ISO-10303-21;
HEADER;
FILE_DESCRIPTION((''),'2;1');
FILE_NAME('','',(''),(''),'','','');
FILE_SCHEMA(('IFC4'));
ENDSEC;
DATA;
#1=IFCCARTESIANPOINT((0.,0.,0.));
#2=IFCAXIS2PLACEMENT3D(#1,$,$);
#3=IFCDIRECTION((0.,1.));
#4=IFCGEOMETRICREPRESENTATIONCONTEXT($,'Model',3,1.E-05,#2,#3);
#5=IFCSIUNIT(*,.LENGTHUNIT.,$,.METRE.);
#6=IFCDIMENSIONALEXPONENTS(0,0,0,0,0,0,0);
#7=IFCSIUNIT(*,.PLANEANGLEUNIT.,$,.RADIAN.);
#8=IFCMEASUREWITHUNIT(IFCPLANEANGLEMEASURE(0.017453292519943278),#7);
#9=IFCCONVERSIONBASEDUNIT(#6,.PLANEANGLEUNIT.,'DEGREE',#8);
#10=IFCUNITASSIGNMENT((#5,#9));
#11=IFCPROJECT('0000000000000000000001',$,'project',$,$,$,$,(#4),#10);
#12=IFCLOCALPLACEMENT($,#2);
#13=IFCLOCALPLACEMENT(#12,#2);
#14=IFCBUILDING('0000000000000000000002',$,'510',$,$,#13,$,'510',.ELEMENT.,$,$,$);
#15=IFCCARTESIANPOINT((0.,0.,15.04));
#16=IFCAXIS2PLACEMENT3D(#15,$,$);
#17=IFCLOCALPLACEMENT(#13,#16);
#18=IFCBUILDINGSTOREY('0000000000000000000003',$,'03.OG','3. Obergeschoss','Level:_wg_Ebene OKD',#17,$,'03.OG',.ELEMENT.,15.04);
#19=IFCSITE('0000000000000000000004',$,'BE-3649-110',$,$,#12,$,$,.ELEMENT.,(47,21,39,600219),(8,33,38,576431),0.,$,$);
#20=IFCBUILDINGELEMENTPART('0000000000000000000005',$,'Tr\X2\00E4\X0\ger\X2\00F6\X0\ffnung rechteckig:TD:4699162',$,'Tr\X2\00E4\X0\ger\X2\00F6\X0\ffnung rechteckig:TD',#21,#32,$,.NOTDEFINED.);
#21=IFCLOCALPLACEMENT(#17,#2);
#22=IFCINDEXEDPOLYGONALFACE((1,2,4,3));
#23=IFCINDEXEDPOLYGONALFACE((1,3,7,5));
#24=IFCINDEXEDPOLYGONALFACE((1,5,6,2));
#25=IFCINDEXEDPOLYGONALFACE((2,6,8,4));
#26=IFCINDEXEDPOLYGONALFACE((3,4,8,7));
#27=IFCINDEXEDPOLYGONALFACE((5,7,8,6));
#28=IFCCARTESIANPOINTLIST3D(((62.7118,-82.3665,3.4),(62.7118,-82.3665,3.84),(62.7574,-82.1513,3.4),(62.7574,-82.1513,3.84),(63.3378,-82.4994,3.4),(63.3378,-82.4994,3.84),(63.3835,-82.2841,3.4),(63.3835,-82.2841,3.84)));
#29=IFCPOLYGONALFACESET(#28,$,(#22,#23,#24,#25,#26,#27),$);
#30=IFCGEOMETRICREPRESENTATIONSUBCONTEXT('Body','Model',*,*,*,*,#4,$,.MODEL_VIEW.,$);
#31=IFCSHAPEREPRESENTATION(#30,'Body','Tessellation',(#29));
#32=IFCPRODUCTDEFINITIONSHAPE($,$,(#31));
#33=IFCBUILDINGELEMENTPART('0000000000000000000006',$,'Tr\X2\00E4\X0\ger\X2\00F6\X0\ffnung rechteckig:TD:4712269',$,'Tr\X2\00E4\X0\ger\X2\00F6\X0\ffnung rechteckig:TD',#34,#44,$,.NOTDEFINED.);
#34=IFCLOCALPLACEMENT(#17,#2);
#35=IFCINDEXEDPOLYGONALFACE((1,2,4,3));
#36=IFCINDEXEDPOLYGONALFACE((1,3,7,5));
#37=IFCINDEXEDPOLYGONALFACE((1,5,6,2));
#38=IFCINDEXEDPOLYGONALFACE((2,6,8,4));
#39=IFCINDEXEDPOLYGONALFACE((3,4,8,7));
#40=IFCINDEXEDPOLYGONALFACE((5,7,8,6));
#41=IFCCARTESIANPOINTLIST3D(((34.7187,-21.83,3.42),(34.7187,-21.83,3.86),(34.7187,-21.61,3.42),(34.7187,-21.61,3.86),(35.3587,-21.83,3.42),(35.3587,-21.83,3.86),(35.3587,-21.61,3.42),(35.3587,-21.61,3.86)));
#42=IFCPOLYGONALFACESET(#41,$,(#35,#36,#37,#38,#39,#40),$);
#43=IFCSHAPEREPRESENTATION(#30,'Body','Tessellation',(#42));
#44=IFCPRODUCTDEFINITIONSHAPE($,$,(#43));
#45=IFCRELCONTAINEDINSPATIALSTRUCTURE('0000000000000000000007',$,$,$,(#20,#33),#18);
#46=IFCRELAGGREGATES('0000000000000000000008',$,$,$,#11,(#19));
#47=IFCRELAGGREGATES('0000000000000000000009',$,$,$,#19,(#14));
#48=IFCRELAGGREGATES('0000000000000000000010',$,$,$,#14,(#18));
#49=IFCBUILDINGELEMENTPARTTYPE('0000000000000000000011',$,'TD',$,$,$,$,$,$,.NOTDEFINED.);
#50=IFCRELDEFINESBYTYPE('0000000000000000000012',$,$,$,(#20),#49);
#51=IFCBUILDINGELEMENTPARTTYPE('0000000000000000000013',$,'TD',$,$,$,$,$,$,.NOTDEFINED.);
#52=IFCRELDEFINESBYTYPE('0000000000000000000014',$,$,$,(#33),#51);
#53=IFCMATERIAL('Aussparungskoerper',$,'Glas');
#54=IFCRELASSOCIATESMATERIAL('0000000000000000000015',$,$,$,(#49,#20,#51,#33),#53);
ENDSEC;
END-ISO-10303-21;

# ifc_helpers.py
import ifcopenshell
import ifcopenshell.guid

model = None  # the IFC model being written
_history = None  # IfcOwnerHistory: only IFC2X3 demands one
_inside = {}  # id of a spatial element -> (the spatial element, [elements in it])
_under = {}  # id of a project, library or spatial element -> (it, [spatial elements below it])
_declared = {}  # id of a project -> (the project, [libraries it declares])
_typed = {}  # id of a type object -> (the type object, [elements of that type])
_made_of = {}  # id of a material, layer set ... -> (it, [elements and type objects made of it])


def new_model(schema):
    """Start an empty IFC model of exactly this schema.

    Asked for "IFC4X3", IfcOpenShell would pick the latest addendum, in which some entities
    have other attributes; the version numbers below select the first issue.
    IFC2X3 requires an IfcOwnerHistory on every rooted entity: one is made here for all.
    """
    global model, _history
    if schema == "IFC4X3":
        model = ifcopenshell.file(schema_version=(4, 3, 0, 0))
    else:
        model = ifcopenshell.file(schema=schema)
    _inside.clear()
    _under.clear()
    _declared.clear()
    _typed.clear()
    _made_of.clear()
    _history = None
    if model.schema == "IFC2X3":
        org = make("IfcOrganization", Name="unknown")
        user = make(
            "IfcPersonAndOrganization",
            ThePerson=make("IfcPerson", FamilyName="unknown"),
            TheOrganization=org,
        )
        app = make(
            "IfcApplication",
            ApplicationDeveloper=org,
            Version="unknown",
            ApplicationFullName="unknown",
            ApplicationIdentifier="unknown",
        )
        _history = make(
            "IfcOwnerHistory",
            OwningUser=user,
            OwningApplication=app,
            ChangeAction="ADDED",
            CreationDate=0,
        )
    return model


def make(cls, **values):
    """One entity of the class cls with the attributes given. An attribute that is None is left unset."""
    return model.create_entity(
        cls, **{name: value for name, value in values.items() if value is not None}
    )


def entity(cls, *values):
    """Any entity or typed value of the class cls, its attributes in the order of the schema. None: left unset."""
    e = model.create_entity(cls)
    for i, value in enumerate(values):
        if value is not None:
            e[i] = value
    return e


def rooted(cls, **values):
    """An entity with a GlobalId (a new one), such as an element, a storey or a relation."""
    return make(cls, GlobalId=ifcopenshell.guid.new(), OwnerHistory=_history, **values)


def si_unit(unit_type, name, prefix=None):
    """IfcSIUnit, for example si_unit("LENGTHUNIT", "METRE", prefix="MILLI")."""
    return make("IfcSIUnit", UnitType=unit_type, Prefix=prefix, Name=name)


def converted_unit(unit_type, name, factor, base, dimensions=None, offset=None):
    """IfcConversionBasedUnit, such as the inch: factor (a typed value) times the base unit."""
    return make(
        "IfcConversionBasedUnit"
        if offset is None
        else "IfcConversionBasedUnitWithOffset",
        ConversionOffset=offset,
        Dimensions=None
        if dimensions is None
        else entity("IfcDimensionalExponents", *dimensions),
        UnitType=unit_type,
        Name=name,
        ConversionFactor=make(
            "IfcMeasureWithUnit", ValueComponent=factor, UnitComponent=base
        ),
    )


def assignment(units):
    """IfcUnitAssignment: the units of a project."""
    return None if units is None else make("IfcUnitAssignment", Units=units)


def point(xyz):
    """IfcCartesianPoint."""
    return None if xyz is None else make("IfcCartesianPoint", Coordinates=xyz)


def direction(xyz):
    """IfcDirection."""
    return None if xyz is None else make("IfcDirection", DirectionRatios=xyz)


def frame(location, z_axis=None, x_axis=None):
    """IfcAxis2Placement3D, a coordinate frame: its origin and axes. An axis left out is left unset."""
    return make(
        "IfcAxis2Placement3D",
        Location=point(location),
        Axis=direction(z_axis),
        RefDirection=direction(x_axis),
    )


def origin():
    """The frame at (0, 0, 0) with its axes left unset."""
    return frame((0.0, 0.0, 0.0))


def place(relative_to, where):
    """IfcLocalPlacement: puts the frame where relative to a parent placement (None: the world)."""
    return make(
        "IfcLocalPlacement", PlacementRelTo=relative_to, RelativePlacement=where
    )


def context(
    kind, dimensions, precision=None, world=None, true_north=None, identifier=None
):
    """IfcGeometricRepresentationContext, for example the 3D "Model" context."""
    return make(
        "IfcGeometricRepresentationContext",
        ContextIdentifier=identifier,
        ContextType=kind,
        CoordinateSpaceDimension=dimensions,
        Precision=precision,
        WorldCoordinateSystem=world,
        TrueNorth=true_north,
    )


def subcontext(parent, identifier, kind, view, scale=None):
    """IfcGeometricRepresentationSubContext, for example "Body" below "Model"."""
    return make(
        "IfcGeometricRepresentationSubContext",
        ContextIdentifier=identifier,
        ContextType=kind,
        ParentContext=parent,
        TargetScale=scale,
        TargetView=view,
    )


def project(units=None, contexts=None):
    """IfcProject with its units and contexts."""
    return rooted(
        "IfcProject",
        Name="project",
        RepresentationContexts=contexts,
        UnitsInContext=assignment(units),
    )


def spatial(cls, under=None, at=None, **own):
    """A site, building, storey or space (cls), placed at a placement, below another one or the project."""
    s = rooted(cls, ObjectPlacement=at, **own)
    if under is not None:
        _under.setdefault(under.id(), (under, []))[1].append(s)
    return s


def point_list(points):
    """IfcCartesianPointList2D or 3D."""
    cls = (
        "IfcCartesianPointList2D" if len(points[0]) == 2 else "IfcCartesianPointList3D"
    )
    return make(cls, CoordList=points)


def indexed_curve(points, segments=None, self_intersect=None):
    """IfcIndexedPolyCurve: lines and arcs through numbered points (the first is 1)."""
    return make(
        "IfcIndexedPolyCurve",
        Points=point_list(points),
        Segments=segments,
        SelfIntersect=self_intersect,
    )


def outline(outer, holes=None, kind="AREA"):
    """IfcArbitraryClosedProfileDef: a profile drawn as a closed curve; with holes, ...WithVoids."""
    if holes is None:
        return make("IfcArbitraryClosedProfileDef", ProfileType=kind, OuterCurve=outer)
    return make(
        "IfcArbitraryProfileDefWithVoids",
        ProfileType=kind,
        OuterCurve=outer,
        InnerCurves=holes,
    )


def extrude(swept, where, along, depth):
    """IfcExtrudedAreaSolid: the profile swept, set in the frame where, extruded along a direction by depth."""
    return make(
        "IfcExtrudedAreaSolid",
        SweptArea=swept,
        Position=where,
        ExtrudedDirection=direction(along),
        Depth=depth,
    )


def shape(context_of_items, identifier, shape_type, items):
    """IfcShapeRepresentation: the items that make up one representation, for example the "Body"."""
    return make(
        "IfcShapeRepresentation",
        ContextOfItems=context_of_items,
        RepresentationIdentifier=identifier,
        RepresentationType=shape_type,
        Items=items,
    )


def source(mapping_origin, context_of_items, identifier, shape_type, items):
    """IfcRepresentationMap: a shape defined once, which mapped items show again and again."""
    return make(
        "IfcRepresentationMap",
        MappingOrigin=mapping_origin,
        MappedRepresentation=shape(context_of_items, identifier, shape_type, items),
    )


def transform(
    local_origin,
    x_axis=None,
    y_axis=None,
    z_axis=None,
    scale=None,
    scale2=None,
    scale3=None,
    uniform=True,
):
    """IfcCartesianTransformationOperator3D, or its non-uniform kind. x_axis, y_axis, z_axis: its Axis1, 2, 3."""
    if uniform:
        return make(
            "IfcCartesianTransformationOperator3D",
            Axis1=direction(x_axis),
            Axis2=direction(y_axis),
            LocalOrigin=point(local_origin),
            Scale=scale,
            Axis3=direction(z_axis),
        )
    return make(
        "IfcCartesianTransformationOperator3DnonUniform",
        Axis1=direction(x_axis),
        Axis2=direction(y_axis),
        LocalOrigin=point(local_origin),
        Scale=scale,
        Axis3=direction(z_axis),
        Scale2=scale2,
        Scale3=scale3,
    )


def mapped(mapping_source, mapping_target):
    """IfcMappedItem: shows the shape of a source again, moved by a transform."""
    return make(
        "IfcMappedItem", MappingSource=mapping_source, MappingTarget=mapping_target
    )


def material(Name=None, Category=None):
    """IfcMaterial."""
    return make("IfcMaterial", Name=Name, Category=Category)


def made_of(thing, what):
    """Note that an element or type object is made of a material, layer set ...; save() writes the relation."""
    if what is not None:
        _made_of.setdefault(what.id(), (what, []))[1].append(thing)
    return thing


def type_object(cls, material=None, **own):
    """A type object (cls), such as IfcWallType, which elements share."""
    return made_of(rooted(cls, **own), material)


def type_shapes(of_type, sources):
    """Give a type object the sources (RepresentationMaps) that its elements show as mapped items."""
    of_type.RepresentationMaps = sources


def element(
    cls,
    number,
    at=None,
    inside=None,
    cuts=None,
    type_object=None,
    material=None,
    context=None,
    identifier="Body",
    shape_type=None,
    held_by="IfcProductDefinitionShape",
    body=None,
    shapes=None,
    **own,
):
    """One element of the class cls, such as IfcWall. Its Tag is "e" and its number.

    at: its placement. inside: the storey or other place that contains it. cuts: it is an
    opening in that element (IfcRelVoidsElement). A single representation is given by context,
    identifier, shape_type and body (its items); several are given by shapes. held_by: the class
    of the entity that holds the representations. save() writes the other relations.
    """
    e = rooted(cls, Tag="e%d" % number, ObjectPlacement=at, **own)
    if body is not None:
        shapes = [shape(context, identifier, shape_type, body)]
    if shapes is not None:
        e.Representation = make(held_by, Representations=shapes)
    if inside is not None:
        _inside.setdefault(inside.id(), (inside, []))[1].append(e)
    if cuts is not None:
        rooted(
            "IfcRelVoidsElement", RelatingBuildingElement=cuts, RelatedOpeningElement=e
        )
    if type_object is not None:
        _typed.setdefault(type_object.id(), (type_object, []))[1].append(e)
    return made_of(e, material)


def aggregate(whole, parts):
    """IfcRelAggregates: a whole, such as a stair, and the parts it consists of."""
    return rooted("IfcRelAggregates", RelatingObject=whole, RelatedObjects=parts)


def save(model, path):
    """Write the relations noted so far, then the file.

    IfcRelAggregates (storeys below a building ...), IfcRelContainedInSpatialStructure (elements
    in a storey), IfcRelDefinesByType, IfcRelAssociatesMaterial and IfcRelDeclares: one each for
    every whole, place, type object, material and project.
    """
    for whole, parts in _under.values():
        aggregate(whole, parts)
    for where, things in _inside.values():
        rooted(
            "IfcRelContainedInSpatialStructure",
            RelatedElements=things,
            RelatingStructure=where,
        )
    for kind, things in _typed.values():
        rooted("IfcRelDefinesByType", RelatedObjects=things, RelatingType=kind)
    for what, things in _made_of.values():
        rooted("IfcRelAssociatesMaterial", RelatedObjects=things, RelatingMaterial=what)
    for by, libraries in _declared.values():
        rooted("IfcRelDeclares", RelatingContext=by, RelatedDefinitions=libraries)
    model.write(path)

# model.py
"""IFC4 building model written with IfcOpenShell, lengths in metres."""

from ifc_helpers import new_model, entity, si_unit, converted_unit, direction, frame, origin, place, context, subcontext, project, spatial, indexed_curve, outline, extrude, source, transform, mapped, material, type_object, type_shapes, element, save


model = new_model("IFC4")

# Units and contexts
model_context = context("Model", 3, precision=1e-05, world=origin(), true_north=direction((0.0, 1.0)))
body_context = subcontext(model_context, "Body", "Model", "MODEL_VIEW")
ifc_project = project(units=[si_unit("LENGTHUNIT", "METRE"), converted_unit("PLANEANGLEUNIT", "DEGREE", entity("IfcPlaneAngleMeasure", 0.017453292519943278), si_unit("PLANEANGLEUNIT", "RADIAN"), dimensions=[0, 0, 0, 0, 0, 0, 0])], contexts=[model_context])

# Site, building, storey
site_placement = place(None, origin())
site = spatial("IfcSite", under=ifc_project, at=site_placement, Name="BE-3649-110", CompositionType="ELEMENT", RefLatitude=(47, 21, 39, 600219), RefLongitude=(8, 33, 38, 576431), RefElevation=0.0)
building_placement = place(site_placement, origin())
building = spatial("IfcBuilding", under=site, at=building_placement, Name="510", LongName="510", CompositionType="ELEMENT")
storey_placement = place(building_placement, frame((0.0, 0.0, 15.04)))
storey = spatial("IfcBuildingStorey", under=building, at=storey_placement, Name="03.OG", Description="3. Obergeschoss", ObjectType="Level:_wg_Ebene OKD", LongName="03.OG", CompositionType="ELEMENT", Elevation=15.04)

# Building element parts
ifc_material_1 = material(Name="Aussparungskoerper", Category="Glas")
building_element_part_type_1 = type_object("IfcBuildingElementPartType", Name="TD", PredefinedType="NOTDEFINED", material=ifc_material_1)
shared_shape_1 = source(origin(), body_context, "Body", "SweptSolid", [
    extrude(outline(indexed_curve([(-0.22, -0.32), (0.22, -0.32), (0.22, 0.32), (-0.22, 0.32), (-0.22, -0.32)], self_intersect=False)), frame((0.0, 0.0, -0.22), z_axis=(0.0, 0.0, 1.0), x_axis=(0.0, 1.0, 0.0)), (0.0, 0.0, 1.0), 0.22),
])
type_shapes(building_element_part_type_1, [shared_shape_1])
building_element_part_1_placement = place(storey_placement, frame((63.0248, -82.4329, 3.62), z_axis=(-0.207566, -0.978221, 0.0), x_axis=(0.978221, -0.207566, 0.0)))
element("IfcBuildingElementPart", 1, at=building_element_part_1_placement, inside=storey, type_object=building_element_part_type_1, material=ifc_material_1, Name="Trägeröffnung rechteckig:TD:4699162", ObjectType="Trägeröffnung rechteckig:TD", PredefinedType="NOTDEFINED", context=body_context, shape_type="MappedRepresentation", body=[
    mapped(shared_shape_1, transform((0.0, 0.0, 0.0), scale=1.0)),
])
building_element_part_type_2 = type_object("IfcBuildingElementPartType", Name="TD", PredefinedType="NOTDEFINED", material=ifc_material_1)
shared_shape_2 = source(origin(), body_context, "Body", "SweptSolid", [
    extrude(outline(indexed_curve([(-0.11, -0.32), (0.11, -0.32), (0.11, 0.32), (-0.11, 0.32), (-0.11, -0.32)], self_intersect=False)), frame((35.0387, -21.72, -0.44), z_axis=(0.0, 0.0, 1.0), x_axis=(0.0, 1.0, 0.0)), (0.0, 0.0, 1.0), 0.44),
])
type_shapes(building_element_part_type_2, [shared_shape_2])
building_element_part_2_placement = place(storey_placement, frame((0.0, 0.0, 3.86)))
element("IfcBuildingElementPart", 2, at=building_element_part_2_placement, inside=storey, type_object=building_element_part_type_2, material=ifc_material_1, Name="Trägeröffnung rechteckig:TD:4712269", ObjectType="Trägeröffnung rechteckig:TD", PredefinedType="NOTDEFINED", context=body_context, shape_type="MappedRepresentation", body=[
    mapped(shared_shape_2, transform((0.0, 0.0, 0.0), scale=1.0)),
])

save(model, "model.ifc")
